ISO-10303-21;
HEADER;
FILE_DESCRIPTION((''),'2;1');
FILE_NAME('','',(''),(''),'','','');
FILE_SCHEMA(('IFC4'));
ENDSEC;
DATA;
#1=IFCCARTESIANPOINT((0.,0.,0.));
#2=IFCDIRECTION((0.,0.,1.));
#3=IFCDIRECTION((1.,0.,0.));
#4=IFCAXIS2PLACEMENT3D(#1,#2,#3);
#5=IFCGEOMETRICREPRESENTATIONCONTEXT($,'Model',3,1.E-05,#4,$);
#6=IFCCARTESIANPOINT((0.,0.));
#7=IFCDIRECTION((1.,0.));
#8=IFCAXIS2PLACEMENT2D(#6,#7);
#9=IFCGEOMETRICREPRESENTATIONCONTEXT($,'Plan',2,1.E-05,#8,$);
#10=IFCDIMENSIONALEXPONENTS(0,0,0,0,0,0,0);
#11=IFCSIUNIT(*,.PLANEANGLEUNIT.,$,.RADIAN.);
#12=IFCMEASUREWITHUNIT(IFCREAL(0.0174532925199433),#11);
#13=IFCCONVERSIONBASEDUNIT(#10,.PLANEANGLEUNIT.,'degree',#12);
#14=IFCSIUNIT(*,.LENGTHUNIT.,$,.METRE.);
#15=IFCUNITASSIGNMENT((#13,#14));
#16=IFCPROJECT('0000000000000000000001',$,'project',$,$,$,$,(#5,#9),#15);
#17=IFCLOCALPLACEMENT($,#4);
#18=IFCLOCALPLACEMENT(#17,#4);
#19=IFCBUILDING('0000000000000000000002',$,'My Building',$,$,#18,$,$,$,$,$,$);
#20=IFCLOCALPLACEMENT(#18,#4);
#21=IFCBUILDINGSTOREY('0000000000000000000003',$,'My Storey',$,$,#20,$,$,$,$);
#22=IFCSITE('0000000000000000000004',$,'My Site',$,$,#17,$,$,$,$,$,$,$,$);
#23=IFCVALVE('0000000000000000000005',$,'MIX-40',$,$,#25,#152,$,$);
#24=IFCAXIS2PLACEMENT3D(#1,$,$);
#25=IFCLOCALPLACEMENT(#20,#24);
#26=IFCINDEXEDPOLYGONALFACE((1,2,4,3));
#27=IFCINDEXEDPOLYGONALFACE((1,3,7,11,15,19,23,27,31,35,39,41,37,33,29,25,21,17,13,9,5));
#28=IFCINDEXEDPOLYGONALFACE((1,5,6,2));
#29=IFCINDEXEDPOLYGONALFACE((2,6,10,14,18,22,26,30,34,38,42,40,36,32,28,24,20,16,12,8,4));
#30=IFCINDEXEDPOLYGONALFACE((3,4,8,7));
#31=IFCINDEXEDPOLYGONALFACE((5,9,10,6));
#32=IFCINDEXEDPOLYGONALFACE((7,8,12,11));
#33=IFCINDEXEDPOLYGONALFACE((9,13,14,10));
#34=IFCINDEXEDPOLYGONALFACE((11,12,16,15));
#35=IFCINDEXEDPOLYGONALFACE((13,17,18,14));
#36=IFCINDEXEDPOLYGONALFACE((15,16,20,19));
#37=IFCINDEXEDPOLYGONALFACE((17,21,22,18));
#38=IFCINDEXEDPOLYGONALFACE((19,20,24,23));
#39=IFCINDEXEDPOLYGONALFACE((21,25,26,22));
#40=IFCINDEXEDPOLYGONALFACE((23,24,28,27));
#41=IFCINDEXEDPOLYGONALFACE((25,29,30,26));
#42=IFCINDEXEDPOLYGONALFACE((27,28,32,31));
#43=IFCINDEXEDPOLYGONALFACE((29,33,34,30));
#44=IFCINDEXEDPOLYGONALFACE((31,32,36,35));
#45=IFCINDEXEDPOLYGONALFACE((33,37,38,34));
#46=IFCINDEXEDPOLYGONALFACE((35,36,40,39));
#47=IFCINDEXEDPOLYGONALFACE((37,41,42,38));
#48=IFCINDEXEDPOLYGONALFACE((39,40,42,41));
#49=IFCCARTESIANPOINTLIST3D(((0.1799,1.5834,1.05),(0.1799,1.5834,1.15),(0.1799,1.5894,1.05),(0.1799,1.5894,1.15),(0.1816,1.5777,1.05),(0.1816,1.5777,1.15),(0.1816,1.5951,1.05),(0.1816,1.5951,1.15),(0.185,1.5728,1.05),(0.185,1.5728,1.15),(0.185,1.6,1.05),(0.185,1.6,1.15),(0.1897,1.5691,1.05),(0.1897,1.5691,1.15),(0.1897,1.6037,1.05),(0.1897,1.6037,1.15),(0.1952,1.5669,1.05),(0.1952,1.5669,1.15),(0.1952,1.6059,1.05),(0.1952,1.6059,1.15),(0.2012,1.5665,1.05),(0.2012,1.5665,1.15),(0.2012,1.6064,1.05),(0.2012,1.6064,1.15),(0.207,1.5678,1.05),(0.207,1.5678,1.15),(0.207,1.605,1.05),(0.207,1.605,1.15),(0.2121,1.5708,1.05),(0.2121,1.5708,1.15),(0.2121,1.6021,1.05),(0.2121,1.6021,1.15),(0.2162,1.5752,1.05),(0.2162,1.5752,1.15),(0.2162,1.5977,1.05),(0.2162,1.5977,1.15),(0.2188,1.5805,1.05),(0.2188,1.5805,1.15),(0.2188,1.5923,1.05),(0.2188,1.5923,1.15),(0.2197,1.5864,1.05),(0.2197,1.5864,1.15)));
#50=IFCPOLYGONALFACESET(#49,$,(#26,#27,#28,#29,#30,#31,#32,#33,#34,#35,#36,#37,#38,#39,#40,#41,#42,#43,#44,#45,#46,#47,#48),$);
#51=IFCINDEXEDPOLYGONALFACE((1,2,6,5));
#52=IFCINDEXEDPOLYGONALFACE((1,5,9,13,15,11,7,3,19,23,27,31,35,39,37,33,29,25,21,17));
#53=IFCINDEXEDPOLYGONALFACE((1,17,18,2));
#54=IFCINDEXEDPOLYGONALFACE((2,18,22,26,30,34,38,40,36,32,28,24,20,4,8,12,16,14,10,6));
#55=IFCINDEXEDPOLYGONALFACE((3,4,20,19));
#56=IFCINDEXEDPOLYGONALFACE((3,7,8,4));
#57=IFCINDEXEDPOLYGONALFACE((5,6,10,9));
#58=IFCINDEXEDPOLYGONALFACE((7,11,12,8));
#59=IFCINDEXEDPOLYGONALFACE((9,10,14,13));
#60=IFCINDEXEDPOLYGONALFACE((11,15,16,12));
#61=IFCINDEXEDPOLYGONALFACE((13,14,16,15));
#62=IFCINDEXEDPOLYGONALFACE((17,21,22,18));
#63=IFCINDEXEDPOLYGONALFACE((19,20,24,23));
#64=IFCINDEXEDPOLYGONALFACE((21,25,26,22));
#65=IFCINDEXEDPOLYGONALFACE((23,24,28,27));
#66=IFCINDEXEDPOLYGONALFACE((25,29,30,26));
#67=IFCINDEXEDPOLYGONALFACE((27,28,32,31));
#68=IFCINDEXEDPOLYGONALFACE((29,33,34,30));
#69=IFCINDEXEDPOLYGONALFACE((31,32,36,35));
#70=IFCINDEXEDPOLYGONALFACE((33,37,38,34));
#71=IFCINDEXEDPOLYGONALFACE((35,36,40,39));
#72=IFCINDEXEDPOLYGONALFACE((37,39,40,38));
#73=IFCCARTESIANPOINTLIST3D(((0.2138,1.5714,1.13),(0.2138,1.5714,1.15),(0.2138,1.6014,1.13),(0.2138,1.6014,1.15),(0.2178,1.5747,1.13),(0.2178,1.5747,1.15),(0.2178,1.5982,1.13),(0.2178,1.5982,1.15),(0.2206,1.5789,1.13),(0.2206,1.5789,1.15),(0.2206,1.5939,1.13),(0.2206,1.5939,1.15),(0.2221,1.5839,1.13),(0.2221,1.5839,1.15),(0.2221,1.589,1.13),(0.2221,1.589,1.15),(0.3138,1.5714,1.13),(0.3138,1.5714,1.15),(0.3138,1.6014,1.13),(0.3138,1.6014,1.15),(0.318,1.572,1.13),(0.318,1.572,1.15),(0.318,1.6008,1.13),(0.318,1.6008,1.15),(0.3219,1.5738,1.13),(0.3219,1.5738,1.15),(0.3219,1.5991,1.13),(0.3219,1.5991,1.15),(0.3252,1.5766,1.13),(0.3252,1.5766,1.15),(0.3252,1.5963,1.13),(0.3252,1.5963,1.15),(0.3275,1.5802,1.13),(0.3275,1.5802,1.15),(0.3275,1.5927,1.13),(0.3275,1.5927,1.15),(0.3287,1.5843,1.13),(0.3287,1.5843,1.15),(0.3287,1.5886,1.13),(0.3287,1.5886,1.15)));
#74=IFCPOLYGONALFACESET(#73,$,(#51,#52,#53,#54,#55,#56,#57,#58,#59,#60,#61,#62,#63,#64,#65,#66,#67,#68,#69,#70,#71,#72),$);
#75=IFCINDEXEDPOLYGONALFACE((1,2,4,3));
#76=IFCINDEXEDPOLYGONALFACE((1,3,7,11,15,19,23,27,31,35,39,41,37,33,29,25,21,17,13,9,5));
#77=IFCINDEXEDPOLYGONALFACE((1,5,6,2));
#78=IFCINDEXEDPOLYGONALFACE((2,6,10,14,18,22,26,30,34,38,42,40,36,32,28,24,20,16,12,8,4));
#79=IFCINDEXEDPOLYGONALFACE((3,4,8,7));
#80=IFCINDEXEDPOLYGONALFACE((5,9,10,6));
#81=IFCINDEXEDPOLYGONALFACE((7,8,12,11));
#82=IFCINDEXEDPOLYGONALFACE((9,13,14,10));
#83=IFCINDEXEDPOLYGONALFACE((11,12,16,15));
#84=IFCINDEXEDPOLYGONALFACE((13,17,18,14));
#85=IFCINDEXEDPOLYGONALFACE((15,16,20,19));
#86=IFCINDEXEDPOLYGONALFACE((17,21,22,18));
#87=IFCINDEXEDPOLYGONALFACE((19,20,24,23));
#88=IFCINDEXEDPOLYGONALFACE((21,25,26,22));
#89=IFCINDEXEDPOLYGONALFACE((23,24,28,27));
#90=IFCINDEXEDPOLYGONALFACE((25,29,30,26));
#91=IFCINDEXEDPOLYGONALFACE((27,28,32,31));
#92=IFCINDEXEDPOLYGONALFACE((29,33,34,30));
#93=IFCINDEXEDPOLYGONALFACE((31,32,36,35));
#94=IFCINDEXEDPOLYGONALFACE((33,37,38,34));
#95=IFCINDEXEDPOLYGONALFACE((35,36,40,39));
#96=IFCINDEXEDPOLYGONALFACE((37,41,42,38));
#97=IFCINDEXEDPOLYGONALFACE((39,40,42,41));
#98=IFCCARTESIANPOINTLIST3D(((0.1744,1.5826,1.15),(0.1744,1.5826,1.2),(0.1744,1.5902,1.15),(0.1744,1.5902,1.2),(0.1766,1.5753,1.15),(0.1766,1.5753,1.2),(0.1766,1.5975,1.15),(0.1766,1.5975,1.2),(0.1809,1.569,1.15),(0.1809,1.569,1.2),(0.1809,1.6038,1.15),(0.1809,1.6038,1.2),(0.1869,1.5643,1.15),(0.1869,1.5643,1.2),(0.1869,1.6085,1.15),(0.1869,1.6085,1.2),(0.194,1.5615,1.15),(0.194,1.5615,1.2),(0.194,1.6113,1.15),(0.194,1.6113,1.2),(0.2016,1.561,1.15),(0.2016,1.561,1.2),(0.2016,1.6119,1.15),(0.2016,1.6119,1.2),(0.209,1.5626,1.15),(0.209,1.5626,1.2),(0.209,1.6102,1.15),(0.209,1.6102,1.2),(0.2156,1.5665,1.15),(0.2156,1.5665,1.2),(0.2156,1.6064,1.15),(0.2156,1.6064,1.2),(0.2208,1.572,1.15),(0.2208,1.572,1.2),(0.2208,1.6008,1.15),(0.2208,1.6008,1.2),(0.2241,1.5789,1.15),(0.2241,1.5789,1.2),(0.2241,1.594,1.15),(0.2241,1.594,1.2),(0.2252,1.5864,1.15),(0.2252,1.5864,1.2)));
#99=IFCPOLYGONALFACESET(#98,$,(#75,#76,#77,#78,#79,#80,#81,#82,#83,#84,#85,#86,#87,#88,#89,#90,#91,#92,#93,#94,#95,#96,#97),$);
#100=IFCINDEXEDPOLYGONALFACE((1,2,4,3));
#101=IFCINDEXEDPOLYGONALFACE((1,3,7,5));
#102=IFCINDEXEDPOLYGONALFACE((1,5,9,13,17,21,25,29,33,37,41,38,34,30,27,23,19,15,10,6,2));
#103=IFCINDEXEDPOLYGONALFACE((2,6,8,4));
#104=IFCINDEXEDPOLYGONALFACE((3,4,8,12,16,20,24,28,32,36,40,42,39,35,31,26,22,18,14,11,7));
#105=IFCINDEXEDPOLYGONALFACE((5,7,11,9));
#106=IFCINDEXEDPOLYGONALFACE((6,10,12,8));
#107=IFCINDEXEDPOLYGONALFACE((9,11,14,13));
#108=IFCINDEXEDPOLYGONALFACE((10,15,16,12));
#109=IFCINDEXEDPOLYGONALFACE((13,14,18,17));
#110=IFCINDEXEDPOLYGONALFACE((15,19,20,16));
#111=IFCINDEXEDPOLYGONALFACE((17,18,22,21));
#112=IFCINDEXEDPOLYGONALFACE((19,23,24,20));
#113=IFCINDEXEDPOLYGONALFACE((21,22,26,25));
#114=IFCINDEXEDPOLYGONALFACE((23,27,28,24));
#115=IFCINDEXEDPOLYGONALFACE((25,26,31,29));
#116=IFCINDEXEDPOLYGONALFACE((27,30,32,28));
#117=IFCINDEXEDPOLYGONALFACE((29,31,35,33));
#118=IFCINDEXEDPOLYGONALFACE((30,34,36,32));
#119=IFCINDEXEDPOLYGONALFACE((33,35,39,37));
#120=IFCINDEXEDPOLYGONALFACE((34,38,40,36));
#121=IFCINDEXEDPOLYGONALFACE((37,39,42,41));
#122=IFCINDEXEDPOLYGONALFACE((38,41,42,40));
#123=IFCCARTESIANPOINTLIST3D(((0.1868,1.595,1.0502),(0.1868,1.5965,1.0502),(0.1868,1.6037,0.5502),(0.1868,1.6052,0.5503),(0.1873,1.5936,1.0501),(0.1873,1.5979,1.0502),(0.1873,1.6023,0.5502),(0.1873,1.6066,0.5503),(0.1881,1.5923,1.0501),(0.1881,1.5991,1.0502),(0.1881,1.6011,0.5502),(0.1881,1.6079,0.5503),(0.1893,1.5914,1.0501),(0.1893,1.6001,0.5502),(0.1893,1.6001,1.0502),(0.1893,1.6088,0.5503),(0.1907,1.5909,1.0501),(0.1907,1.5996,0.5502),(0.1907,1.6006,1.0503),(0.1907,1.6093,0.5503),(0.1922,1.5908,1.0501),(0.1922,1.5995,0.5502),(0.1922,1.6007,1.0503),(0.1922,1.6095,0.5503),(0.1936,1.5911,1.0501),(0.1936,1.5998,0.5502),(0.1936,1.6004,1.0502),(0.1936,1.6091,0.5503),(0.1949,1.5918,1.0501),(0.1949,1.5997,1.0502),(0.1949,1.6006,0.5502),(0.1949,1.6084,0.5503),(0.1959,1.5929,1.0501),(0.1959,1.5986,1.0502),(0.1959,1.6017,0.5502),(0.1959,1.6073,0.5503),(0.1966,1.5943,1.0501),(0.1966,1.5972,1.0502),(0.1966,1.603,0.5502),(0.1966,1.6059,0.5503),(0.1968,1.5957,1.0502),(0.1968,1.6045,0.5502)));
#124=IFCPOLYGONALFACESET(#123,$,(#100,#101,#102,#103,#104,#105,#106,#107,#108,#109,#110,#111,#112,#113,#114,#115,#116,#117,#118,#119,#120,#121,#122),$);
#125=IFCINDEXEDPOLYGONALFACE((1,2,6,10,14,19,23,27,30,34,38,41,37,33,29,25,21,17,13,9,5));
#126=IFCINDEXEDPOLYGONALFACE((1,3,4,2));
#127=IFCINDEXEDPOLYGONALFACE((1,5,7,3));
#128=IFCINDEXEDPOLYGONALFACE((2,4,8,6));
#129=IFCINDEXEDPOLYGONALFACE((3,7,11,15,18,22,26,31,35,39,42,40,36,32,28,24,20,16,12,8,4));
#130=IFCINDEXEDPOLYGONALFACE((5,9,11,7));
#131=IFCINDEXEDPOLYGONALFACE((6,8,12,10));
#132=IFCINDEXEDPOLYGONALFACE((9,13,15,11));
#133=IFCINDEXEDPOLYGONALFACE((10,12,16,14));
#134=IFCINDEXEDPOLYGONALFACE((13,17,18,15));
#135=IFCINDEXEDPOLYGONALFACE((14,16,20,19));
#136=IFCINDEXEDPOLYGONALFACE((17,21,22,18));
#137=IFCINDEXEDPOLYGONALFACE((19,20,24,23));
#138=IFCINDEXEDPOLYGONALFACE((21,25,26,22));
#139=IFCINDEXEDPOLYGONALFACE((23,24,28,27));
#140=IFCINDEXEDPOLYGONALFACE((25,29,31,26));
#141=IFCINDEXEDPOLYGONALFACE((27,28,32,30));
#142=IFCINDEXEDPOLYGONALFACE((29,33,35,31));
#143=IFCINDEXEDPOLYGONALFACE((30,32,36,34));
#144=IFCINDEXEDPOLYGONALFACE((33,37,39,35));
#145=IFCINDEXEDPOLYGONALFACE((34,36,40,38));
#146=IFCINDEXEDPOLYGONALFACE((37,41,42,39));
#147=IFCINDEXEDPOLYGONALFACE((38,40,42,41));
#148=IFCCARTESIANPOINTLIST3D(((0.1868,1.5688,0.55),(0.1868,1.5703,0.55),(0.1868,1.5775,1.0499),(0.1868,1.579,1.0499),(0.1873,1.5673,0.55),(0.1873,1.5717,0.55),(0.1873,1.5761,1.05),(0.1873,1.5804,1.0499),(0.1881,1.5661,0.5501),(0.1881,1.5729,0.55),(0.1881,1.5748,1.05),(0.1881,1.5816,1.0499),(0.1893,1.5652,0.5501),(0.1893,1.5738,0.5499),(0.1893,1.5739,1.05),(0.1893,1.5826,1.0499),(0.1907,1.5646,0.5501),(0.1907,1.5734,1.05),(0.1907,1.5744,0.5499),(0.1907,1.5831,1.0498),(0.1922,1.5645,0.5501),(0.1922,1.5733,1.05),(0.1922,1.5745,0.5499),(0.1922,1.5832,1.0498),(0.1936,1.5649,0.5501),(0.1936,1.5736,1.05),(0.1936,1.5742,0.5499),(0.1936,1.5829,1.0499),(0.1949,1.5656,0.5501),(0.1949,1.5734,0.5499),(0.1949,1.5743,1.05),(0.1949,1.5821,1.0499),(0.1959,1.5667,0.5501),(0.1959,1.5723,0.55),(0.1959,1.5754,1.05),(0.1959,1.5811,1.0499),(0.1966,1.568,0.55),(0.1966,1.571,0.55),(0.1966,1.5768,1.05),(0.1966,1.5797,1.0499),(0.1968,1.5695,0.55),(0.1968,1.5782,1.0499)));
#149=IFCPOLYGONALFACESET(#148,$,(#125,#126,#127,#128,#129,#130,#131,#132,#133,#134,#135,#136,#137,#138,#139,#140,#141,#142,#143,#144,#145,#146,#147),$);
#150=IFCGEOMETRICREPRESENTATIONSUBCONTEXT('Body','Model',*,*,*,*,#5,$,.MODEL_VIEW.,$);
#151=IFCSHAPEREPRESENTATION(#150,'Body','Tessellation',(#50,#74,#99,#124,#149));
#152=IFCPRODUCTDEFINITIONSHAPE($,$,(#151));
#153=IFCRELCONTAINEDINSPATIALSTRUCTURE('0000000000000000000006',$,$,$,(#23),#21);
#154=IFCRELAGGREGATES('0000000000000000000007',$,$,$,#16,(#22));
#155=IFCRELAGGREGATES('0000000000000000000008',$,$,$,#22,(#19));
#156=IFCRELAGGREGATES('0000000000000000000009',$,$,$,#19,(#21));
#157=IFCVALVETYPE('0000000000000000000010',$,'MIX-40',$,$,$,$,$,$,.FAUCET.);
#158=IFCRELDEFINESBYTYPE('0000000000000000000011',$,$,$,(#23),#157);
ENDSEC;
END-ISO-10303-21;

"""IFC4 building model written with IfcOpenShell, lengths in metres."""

from ifc_helpers import new_model, entity, si_unit, converted_unit, frame, frame_2d, origin_with_axes, origin_2d, origin_2d_with_axis, place, context, subcontext, project, spatial, line, arc, indexed_curve, circle_curve, outline, extrude, source, transform, mapped, type_object, type_shapes, element, save


model = new_model("IFC4")

# Units and contexts
model_context = context("Model", 3, precision=1e-05, world=origin_with_axes())
plan_context = context("Plan", 2, precision=1e-05, world=origin_2d_with_axis())
body_context = subcontext(model_context, "Body", "Model", "MODEL_VIEW")
ifc_project = project(units=[converted_unit("PLANEANGLEUNIT", "degree", entity("IfcReal", 0.0174532925199433), si_unit("PLANEANGLEUNIT", "RADIAN"), dimensions=[0, 0, 0, 0, 0, 0, 0]), si_unit("LENGTHUNIT", "METRE")], contexts=[model_context, plan_context])

# Site, building, storey
site_placement = place(None, origin_with_axes())
site = spatial("IfcSite", under=ifc_project, at=site_placement, Name="My Site")
building_placement = place(site_placement, origin_with_axes())
building = spatial("IfcBuilding", under=site, at=building_placement, Name="My Building")
storey_placement = place(building_placement, origin_with_axes())
storey = spatial("IfcBuildingStorey", under=building, at=storey_placement, Name="My Storey")

# Valve
valve_type = type_object("IfcValveType", Name="MIX-40", PredefinedType="FAUCET")
shared_shape_1 = source(origin_with_axes(), body_context, "Body", "SweptSolid", [
    extrude(outline(circle_curve(frame_2d((0.0, 0.0)), 0.02)), frame((-0.0001, 0.0008, 0.0), z_axis=(0.0, 0.0, 1.0), x_axis=(1.0, 0.0, 0.0)), (0.0, 0.0, 1.0), 0.1),
    extrude(outline(indexed_curve([(0.0032, 0.0013), (0.0117, 0.0163), (0.0032, 0.0313), (0.1032, 0.0313), (0.1183, 0.0163), (0.1032, 0.0013)], segments=[arc(1, 2, 3), line(3, 4), arc(4, 5, 6), line(6, 1)])), frame((0.0108, -0.0156, 0.08), z_axis=(0.0, 0.0, 1.0), x_axis=(1.0, 0.0, 0.0)), (0.0, 0.0, 1.0), 0.02),
    extrude(outline(circle_curve(frame_2d((0.0, 0.0)), 0.0255)), frame((-0.0001, 0.0008, 0.1), z_axis=(0.0, 0.0, 1.0), x_axis=(1.0, 0.0, 0.0)), (0.0, 0.0, 1.0), 0.05),
    extrude(outline(circle_curve(origin_2d(), 0.005)), frame((-0.0079, 0.0188, -0.4998), z_axis=(0.0, -0.017452, 0.999848), x_axis=(1.0, 0.0, 0.0)), (0.0, 0.0, 1.0), 0.5),
    extrude(outline(circle_curve(origin_2d(), 0.005)), frame((-0.0079, -0.0162, -0.5), z_axis=(0.0, 0.017452, 0.999848), x_axis=(1.0, 0.0, 0.0)), (0.0, 0.0, 1.0), 0.5),
])
type_shapes(valve_type, [shared_shape_1])
for number, where, z_axis, x_axis, name in (
    (1, (0.1997, 1.5857, 1.05), (0.0, 0.0, 1.0), (1.0, 0.0, 0.0), "MIX-40"),
):
    element("IfcValve", number, at=place(storey_placement, frame(where, z_axis=z_axis, x_axis=x_axis)), inside=storey, type_object=valve_type, Name=name, context=body_context, shape_type="MappedRepresentation", body=[
        mapped(shared_shape_1, transform((0.0, 0.0, 0.0), x_axis=(1.0, 0.0, 0.0), y_axis=(0.0, 1.0, 0.0), z_axis=(0.0, 0.0, 1.0), scale=1.0)),
    ])

save(model, "model.ifc")
